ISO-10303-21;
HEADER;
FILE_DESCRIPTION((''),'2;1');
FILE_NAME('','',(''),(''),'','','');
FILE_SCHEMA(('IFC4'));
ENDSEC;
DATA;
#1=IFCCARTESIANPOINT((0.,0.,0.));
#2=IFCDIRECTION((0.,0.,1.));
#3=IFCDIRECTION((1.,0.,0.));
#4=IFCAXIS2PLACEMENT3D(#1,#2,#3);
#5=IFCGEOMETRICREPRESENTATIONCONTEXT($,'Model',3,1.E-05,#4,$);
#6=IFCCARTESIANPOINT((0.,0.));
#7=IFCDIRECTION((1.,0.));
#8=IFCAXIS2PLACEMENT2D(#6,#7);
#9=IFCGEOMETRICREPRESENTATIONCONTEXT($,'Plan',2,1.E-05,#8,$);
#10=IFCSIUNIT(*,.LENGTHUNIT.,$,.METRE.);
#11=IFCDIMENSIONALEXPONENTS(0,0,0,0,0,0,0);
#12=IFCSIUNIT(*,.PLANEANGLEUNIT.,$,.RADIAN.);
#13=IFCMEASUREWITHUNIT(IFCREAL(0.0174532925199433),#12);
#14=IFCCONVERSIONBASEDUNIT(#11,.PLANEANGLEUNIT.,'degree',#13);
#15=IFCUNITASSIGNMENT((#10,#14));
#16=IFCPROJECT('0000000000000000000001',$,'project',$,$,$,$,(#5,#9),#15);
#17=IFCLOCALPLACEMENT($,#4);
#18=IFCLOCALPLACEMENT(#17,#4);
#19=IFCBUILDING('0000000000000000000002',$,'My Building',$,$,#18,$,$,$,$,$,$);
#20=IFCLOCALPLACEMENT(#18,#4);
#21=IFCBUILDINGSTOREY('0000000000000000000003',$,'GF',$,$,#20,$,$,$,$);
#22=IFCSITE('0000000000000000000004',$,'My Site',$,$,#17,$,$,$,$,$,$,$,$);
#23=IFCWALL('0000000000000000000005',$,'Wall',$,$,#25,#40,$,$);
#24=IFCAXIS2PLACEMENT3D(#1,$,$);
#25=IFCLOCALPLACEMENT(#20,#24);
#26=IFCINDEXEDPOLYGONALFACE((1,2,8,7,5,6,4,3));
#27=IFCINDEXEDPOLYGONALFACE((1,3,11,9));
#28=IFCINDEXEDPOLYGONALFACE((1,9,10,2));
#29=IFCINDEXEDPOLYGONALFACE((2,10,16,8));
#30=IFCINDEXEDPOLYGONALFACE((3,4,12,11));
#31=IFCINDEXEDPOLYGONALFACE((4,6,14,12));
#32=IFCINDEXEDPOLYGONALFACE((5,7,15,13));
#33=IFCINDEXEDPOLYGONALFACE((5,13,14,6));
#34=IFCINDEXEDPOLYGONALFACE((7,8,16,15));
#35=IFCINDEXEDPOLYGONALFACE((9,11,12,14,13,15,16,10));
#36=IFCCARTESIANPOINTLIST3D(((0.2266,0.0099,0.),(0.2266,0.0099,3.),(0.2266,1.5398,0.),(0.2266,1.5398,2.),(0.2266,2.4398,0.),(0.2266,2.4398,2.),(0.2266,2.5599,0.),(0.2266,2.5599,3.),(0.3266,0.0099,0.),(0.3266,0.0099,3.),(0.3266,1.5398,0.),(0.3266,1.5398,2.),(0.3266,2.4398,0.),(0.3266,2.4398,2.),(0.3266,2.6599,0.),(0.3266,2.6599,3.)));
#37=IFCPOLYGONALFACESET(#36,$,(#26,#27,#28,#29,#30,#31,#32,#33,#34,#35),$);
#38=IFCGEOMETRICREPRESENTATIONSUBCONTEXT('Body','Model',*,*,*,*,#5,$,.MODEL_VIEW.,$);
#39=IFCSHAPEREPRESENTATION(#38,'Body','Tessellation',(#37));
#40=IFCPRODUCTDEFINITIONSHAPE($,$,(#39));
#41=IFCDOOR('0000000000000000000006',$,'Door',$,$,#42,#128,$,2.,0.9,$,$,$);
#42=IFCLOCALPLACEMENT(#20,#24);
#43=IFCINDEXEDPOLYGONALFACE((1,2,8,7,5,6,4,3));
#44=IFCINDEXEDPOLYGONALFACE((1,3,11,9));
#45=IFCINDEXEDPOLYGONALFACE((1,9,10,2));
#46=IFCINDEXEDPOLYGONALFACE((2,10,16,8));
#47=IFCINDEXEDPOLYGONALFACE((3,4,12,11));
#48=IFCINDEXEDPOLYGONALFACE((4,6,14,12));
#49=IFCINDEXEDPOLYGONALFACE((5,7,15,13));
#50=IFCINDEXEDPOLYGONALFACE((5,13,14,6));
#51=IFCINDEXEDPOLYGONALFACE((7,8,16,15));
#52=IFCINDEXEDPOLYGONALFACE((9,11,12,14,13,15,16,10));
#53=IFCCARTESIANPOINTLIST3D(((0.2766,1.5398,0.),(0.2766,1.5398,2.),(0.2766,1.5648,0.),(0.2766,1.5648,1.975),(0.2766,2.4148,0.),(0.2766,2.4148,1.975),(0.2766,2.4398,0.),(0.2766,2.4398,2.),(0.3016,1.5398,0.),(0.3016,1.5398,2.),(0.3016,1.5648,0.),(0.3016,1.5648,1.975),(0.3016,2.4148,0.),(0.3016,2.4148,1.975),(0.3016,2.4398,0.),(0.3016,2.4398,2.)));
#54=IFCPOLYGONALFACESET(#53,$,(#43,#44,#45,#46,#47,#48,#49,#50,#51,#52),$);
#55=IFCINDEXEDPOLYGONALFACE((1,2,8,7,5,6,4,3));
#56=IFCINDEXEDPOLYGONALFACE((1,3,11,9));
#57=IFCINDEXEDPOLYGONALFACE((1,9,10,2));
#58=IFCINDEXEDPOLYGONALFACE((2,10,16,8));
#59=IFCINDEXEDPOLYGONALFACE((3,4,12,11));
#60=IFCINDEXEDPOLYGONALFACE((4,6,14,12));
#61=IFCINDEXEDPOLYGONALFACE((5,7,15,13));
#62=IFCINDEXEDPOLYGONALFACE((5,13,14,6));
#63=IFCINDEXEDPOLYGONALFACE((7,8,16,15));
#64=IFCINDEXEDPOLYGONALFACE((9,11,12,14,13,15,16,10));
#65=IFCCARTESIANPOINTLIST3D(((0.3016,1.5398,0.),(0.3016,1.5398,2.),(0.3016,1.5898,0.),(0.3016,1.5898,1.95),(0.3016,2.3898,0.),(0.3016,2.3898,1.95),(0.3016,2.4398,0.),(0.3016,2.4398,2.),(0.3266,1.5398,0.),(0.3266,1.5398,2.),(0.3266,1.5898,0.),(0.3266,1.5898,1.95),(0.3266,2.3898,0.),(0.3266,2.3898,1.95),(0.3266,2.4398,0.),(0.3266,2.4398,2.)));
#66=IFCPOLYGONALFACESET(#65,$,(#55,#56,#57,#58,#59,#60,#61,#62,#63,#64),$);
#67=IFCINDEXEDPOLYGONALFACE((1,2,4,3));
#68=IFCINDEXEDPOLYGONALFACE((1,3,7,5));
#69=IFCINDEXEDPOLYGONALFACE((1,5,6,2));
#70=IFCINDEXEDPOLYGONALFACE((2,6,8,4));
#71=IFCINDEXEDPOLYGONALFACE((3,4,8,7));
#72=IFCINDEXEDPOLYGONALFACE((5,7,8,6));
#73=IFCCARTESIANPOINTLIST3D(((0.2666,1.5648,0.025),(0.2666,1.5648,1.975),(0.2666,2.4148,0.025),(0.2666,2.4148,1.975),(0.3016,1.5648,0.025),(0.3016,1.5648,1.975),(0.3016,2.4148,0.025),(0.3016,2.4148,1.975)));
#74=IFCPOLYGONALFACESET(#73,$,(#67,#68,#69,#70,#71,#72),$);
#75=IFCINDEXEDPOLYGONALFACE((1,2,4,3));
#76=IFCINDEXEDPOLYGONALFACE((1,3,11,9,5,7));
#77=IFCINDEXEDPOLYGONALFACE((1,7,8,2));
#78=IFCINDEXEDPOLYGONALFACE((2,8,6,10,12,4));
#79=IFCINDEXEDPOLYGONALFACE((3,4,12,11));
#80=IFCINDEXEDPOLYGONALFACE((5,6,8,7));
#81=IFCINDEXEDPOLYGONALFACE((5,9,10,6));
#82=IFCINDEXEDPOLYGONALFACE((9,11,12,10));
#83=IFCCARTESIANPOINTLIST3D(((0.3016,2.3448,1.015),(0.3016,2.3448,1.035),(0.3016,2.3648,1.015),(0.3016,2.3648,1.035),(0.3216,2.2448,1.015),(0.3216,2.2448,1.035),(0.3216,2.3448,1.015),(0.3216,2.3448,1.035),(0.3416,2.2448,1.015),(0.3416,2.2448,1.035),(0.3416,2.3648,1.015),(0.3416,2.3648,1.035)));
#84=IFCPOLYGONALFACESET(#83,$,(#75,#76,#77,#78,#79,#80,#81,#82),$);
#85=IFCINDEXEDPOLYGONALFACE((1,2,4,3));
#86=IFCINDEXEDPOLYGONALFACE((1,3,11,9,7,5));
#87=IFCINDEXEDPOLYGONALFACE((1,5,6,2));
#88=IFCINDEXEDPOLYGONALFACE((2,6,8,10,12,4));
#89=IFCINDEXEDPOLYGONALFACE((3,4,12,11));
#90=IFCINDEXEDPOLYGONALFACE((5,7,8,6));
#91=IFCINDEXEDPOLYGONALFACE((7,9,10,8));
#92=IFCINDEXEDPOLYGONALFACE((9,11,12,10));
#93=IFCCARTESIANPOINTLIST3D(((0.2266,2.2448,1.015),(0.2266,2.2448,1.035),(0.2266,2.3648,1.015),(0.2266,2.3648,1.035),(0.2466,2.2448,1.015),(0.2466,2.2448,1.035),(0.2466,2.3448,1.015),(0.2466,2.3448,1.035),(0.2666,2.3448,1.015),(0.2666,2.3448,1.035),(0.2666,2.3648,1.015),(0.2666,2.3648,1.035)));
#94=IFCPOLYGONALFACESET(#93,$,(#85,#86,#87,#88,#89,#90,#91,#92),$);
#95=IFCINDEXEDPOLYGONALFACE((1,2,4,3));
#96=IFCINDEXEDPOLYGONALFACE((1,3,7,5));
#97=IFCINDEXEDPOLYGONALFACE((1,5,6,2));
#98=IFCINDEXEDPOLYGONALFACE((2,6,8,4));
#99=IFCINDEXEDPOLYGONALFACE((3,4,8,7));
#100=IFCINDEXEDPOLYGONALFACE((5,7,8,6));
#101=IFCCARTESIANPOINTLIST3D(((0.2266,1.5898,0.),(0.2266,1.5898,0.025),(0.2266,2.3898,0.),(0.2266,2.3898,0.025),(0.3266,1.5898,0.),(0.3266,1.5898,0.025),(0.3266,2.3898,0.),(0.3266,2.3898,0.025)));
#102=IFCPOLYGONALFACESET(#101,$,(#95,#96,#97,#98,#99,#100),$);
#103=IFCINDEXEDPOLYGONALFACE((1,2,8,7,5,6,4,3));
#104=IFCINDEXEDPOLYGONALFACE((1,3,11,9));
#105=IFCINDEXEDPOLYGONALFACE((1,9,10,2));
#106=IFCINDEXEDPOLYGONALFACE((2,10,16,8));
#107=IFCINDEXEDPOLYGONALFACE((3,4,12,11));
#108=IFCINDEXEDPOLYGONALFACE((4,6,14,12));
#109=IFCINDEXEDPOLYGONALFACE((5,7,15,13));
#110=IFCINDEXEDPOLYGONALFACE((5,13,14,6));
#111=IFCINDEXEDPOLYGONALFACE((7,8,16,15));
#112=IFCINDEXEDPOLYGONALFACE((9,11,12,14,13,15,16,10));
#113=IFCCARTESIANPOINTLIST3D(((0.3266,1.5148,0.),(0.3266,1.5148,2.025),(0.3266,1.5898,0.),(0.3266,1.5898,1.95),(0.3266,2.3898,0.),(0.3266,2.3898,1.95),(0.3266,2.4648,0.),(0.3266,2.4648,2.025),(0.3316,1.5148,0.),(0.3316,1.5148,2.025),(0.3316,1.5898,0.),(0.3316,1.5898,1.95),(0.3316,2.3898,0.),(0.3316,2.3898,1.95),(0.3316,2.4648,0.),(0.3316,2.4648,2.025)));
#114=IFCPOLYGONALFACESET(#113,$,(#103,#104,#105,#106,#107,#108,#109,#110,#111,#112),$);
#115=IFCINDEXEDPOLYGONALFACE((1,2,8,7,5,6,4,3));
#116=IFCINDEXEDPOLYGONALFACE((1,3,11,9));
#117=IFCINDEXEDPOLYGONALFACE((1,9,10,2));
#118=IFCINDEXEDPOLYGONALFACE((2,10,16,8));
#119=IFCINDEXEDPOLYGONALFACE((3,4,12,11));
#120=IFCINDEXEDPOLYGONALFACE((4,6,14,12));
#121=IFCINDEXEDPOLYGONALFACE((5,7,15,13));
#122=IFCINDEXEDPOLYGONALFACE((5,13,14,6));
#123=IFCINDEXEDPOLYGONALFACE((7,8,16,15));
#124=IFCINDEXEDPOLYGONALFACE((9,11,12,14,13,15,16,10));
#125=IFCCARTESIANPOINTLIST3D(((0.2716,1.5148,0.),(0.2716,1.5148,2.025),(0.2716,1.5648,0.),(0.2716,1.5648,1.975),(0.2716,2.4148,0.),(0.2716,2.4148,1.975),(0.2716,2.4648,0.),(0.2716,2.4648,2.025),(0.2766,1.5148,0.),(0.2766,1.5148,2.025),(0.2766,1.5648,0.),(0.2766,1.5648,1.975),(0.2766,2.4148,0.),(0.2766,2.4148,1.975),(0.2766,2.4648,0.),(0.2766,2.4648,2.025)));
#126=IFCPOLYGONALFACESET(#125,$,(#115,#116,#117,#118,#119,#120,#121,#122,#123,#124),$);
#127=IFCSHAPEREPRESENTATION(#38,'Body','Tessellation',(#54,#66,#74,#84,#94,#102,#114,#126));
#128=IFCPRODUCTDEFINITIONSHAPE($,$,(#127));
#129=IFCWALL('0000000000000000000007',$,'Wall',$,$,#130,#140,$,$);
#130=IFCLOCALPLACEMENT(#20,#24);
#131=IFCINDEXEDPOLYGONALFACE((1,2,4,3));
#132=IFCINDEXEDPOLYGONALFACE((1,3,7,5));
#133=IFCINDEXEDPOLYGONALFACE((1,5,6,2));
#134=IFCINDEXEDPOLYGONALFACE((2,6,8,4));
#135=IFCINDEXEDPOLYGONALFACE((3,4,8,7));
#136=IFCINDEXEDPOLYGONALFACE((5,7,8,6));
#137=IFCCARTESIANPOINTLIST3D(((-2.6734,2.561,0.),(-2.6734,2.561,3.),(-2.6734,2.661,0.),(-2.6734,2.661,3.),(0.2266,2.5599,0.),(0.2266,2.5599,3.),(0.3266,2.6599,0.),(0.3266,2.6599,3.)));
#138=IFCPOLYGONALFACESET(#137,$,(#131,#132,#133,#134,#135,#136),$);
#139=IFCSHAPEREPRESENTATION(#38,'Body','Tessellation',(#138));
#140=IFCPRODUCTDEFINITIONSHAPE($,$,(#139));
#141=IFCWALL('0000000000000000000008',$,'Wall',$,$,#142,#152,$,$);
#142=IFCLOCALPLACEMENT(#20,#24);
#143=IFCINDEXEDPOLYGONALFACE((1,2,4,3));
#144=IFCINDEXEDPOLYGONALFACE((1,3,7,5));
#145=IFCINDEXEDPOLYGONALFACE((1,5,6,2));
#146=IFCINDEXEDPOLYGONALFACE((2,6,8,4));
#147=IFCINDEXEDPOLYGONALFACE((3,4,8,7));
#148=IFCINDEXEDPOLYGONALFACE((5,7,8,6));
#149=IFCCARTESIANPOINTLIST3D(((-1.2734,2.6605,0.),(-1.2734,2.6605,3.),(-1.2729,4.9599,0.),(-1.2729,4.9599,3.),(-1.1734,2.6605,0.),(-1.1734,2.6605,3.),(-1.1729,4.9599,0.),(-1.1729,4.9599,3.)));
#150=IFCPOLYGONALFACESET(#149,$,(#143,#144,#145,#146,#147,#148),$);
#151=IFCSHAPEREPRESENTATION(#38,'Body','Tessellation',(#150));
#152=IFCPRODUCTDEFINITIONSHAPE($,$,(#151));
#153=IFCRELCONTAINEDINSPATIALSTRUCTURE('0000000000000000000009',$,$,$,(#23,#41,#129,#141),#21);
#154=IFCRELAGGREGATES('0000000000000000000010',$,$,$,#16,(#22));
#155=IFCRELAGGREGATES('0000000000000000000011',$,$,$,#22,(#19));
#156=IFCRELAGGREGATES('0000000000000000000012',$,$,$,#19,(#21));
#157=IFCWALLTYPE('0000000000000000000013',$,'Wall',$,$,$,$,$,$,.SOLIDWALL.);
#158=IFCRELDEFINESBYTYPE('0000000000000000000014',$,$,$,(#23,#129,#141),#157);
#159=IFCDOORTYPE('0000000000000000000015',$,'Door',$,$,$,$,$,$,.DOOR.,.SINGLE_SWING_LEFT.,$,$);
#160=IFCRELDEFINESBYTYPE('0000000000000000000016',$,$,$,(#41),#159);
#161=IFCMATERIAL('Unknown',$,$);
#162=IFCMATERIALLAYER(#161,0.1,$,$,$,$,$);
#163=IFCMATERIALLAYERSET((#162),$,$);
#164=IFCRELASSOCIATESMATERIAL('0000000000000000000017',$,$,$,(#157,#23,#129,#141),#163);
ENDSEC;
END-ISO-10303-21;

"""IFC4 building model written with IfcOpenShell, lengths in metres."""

from ifc_helpers import new_model, entity, si_unit, converted_unit, frame, origin_with_axes, origin_2d_with_axis, place, context, subcontext, project, spatial, line, indexed_curve, outline, extrude, shape, source, transform, mapped, material, layer, layer_set, layer_usage, type_object, type_shapes, element, fill, save


model = new_model("IFC4")

# Units and contexts
model_context = context("Model", 3, precision=1e-05, world=origin_with_axes())
plan_context = context("Plan", 2, precision=1e-05, world=origin_2d_with_axis())
body_context_1 = subcontext(model_context, "Body", "Model", "MODEL_VIEW")
body_context_2 = subcontext(plan_context, "Body", "Plan", "PLAN_VIEW")
ifc_project = project(units=[si_unit("LENGTHUNIT", "METRE"), converted_unit("PLANEANGLEUNIT", "degree", entity("IfcReal", 0.0174532925199433), si_unit("PLANEANGLEUNIT", "RADIAN"), dimensions=[0, 0, 0, 0, 0, 0, 0])], contexts=[model_context, plan_context])

# Site, building, storey
site_placement = place(None, origin_with_axes())
site = spatial("IfcSite", under=ifc_project, at=site_placement, Name="My Site")
building_placement = place(site_placement, origin_with_axes())
building = spatial("IfcBuilding", under=site, at=building_placement, Name="My Building")
storey_placement = place(building_placement, origin_with_axes())
storey = spatial("IfcBuildingStorey", under=building, at=storey_placement, Name="GF")

# Shared definitions
ifc_material_1 = material(Name="Unknown")

# Shared definitions
ifc_layer_1 = layer(ifc_material_1, 0.1)
ifc_layer_set_1 = layer_set([ifc_layer_1])
wall_type = type_object("IfcWallType", Name="Wall", PredefinedType="SOLIDWALL", material=ifc_layer_set_1)
shared_shape_1 = source(origin_with_axes(), body_context_1, "Body", "SweptSolid", [
    extrude(outline(indexed_curve([(0.0, 0.0), (0.9, 0.0), (0.9, 2.0), (0.0, 2.0)], segments=[line(1, 2, 3, 4, 1)])), frame((0.0, -0.6, 0.0), z_axis=(0.0, -1.0, 0.0), x_axis=(1.0, 0.0, 0.0)), (0.0, 0.0, -1.0), 1.2),
])
door_type = type_object("IfcDoorType", Name="Door", OperationType="SINGLE_SWING_LEFT", PredefinedType="DOOR")
shared_shape_2 = source(origin_with_axes(), body_context_1, "Body", "SweptSolid", [
    extrude(outline(indexed_curve([(0.0, 0.0), (0.0, 2.0), (0.9, 2.0), (0.9, 0.0), (0.875, 0.0), (0.875, 1.975), (0.025, 1.975), (0.025, 0.0)], segments=[line(1, 2, 3, 4, 5, 6, 7, 8, 1)])), frame((0.0, 0.025, 0.0), z_axis=(0.0, -1.0, 0.0), x_axis=(1.0, 0.0, 0.0)), (0.0, 0.0, -1.0), 0.025),
    extrude(outline(indexed_curve([(0.0, 0.0), (0.0, 2.0), (0.9, 2.0), (0.9, 0.0), (0.85, 0.0), (0.85, 1.95), (0.05, 1.95), (0.05, 0.0)], segments=[line(1, 2, 3, 4, 5, 6, 7, 8, 1)])), frame((0.0, 0.0, 0.0), z_axis=(0.0, -1.0, 0.0), x_axis=(1.0, 0.0, 0.0)), (0.0, 0.0, -1.0), 0.025),
    extrude(outline(indexed_curve([(0.0, 0.0), (0.85, 0.0), (0.85, 0.035), (0.0, 0.035)], segments=[line(1, 2, 3, 4, 1)])), frame((0.025, 0.025, 0.025), z_axis=(0.0, 0.0, 1.0), x_axis=(1.0, 0.0, 0.0)), (0.0, 0.0, 1.0), 1.95),
    extrude(outline(indexed_curve([(0.0, 0.0), (0.0, -0.04), (-0.12, -0.04), (-0.12, -0.02), (-0.02, -0.02), (-0.02, 0.0)], segments=[line(1, 2, 3, 4, 5, 6, 1)])), frame((0.825, 0.025, 1.015), z_axis=(0.0, 0.0, 1.0), x_axis=(1.0, 0.0, 0.0)), (0.0, 0.0, 1.0), 0.02),
    extrude(outline(indexed_curve([(0.0, 0.0), (0.0, 0.04), (-0.12, 0.04), (-0.12, 0.02), (-0.02, 0.02), (-0.02, 0.0)], segments=[line(1, 2, 3, 4, 5, 6, 1)])), frame((0.825, 0.06, 1.015), z_axis=(0.0, 0.0, 1.0), x_axis=(1.0, 0.0, 0.0)), (0.0, 0.0, 1.0), 0.02),
    extrude(outline(indexed_curve([(0.0, 0.0), (0.8, 0.0), (0.8, 0.1), (0.0, 0.1)], segments=[line(1, 2, 3, 4, 1)])), frame((0.05, 0.0, 0.0), z_axis=(0.0, 0.0, 1.0), x_axis=(1.0, 0.0, 0.0)), (0.0, 0.0, 1.0), 0.025),
    extrude(outline(indexed_curve([(0.0, 0.0), (0.0, 2.025), (0.95, 2.025), (0.95, 0.0), (0.875, 0.0), (0.875, 1.95), (0.075, 1.95), (0.075, 0.0)], segments=[line(1, 2, 3, 4, 5, 6, 7, 8, 1)])), frame((-0.025, -0.005, 0.0), z_axis=(0.0, -1.0, 0.0), x_axis=(1.0, 0.0, 0.0)), (0.0, 0.0, -1.0), 0.005),
    extrude(outline(indexed_curve([(0.0, 0.0), (0.0, 2.025), (0.95, 2.025), (0.95, 0.0), (0.9, 0.0), (0.9, 1.975), (0.05, 1.975), (0.05, 0.0)], segments=[line(1, 2, 3, 4, 5, 6, 7, 8, 1)])), frame((-0.025, 0.05, 0.0), z_axis=(0.0, -1.0, 0.0), x_axis=(1.0, 0.0, 0.0)), (0.0, 0.0, -1.0), 0.005),
])
shared_shape_3 = source(origin_with_axes(), body_context_2, "Body", "Curve2D", [
    entity("IfcIndexedPolyCurve", entity("IfcCartesianPointList2D", [[0.0, 0.0], [0.0, 0.05], [0.025, 0.05], [0.025, 0.025], [0.05, 0.025], [0.05, 0.0]]), [entity("IfcLineIndex", [1, 2, 3, 4, 5, 6, 1])]),
    entity("IfcIndexedPolyCurve", entity("IfcCartesianPointList2D", [[0.9, 0.0], [0.9, 0.05], [0.875, 0.05], [0.875, 0.025], [0.85, 0.025], [0.85, 0.0]]), [entity("IfcLineIndex", [1, 2, 3, 4, 5, 6, 1])]),
    entity("IfcTrimmedCurve", entity("IfcEllipse", entity("IfcAxis2Placement2D", entity("IfcCartesianPoint", [0.06, 0.05]), entity("IfcDirection", [1.0, 0.0])), 0.815, 0.85), [entity("IfcCartesianPoint", [0.875, 0.05])], [entity("IfcCartesianPoint", [0.06, 0.9])], True, "CARTESIAN"),
    entity("IfcIndexedPolyCurve", entity("IfcCartesianPointList2D", [[0.025, 0.05], [0.06, 0.05], [0.06, 0.9], [0.025, 0.9]]), [entity("IfcLineIndex", [1, 2, 3, 4, 1])]),
])
type_shapes(door_type, [shared_shape_2, shared_shape_3])

# Wall, opening, door
ifc_layer_usage_1 = layer_usage(ifc_layer_set_1, "AXIS2", "POSITIVE", 0.0)
wall_1_placement = place(storey_placement, frame((0.3266, 0.0099, 0.0), z_axis=(0.0, 0.0, 1.0), x_axis=(0.0, 1.0, 0.0)))
wall_1 = element("IfcWall", 1, at=wall_1_placement, inside=storey, type_object=wall_type, material=ifc_layer_usage_1, Name="Wall", context=body_context_1, shape_type="SweptSolid", body=[
    extrude(outline(indexed_curve([(0.0, 0.0), (0.0, 0.1), (2.55, 0.1), (2.65, 0.0)], segments=[line(1, 2, 3, 4, 1)])), origin_with_axes(), (0.0, 0.0, 1.0), 3.0),
])
opening_1_placement = place(wall_1_placement, frame((1.5299, 0.0, 0.0), z_axis=(0.0, 0.0, 1.0), x_axis=(1.0, 0.0, 0.0)))
opening_1 = element("IfcOpeningElement", 2, at=opening_1_placement, cuts=wall_1, PredefinedType="OPENING", context=body_context_1, shape_type="MappedRepresentation", body=[
    mapped(shared_shape_1, transform((0.0, 0.0, 0.0), x_axis=(1.0, 0.0, 0.0), y_axis=(0.0, 1.0, 0.0), z_axis=(0.0, 0.0, 1.0), scale=1.0)),
])
door_1_placement = place(opening_1_placement, frame((0.0, 0.0, 0.0), z_axis=(0.0, 0.0, 1.0), x_axis=(1.0, 0.0, 0.0)))
door_1 = element("IfcDoor", 3, at=door_1_placement, inside=storey, type_object=door_type, Name="Door", OverallHeight=2.0, OverallWidth=0.9, shapes=[
    shape(body_context_1, "Body", "MappedRepresentation", [mapped(shared_shape_2, transform((0.0, 0.0, 0.0), x_axis=(1.0, 0.0, 0.0), y_axis=(0.0, 1.0, 0.0), z_axis=(0.0, 0.0, 1.0), scale=1.0))]),
    shape(body_context_2, "Body", "MappedRepresentation", [mapped(shared_shape_3, transform((0.0, 0.0, 0.0), x_axis=(1.0, 0.0, 0.0), y_axis=(0.0, 1.0, 0.0), z_axis=(0.0, 0.0, 1.0), scale=1.0))]),
])
fill(opening_1, door_1)

# Walls
ifc_layer_usage_2 = layer_usage(ifc_layer_set_1, "AXIS2", "POSITIVE", 0.0)
wall_2_placement = place(storey_placement, frame((0.3266, 2.6599, 0.0), z_axis=(0.0, 0.0, 1.0), x_axis=(-1.0, 0.000381, 0.0)))
element("IfcWall", 4, at=wall_2_placement, inside=storey, type_object=wall_type, material=ifc_layer_usage_2, Name="Wall", context=body_context_1, shape_type="SweptSolid", body=[
    extrude(outline(indexed_curve([(0.0, 0.0), (0.1, 0.1), (3.0, 0.1), (3.0, 0.0)], segments=[line(1, 2, 3, 4, 1)])), origin_with_axes(), (0.0, 0.0, 1.0), 3.0),
])
ifc_layer_usage_3 = layer_usage(ifc_layer_set_1, "AXIS2", "POSITIVE", 0.0)
wall_3_placement = place(storey_placement, frame((-1.1734, 2.6605, 0.0), z_axis=(0.0, 0.0, 1.0), x_axis=(0.000197, 1.0, 0.0)))
element("IfcWall", 5, at=wall_3_placement, inside=storey, type_object=wall_type, material=ifc_layer_usage_3, Name="Wall", context=body_context_1, shape_type="SweptSolid", body=[
    extrude(outline(indexed_curve([(0.0, 0.0), (0.0, 0.1), (2.2994, 0.1), (2.2994, 0.0)], segments=[line(1, 2, 3, 4, 1)])), origin_with_axes(), (0.0, 0.0, 1.0), 3.0),
])

save(model, "model.ifc")
